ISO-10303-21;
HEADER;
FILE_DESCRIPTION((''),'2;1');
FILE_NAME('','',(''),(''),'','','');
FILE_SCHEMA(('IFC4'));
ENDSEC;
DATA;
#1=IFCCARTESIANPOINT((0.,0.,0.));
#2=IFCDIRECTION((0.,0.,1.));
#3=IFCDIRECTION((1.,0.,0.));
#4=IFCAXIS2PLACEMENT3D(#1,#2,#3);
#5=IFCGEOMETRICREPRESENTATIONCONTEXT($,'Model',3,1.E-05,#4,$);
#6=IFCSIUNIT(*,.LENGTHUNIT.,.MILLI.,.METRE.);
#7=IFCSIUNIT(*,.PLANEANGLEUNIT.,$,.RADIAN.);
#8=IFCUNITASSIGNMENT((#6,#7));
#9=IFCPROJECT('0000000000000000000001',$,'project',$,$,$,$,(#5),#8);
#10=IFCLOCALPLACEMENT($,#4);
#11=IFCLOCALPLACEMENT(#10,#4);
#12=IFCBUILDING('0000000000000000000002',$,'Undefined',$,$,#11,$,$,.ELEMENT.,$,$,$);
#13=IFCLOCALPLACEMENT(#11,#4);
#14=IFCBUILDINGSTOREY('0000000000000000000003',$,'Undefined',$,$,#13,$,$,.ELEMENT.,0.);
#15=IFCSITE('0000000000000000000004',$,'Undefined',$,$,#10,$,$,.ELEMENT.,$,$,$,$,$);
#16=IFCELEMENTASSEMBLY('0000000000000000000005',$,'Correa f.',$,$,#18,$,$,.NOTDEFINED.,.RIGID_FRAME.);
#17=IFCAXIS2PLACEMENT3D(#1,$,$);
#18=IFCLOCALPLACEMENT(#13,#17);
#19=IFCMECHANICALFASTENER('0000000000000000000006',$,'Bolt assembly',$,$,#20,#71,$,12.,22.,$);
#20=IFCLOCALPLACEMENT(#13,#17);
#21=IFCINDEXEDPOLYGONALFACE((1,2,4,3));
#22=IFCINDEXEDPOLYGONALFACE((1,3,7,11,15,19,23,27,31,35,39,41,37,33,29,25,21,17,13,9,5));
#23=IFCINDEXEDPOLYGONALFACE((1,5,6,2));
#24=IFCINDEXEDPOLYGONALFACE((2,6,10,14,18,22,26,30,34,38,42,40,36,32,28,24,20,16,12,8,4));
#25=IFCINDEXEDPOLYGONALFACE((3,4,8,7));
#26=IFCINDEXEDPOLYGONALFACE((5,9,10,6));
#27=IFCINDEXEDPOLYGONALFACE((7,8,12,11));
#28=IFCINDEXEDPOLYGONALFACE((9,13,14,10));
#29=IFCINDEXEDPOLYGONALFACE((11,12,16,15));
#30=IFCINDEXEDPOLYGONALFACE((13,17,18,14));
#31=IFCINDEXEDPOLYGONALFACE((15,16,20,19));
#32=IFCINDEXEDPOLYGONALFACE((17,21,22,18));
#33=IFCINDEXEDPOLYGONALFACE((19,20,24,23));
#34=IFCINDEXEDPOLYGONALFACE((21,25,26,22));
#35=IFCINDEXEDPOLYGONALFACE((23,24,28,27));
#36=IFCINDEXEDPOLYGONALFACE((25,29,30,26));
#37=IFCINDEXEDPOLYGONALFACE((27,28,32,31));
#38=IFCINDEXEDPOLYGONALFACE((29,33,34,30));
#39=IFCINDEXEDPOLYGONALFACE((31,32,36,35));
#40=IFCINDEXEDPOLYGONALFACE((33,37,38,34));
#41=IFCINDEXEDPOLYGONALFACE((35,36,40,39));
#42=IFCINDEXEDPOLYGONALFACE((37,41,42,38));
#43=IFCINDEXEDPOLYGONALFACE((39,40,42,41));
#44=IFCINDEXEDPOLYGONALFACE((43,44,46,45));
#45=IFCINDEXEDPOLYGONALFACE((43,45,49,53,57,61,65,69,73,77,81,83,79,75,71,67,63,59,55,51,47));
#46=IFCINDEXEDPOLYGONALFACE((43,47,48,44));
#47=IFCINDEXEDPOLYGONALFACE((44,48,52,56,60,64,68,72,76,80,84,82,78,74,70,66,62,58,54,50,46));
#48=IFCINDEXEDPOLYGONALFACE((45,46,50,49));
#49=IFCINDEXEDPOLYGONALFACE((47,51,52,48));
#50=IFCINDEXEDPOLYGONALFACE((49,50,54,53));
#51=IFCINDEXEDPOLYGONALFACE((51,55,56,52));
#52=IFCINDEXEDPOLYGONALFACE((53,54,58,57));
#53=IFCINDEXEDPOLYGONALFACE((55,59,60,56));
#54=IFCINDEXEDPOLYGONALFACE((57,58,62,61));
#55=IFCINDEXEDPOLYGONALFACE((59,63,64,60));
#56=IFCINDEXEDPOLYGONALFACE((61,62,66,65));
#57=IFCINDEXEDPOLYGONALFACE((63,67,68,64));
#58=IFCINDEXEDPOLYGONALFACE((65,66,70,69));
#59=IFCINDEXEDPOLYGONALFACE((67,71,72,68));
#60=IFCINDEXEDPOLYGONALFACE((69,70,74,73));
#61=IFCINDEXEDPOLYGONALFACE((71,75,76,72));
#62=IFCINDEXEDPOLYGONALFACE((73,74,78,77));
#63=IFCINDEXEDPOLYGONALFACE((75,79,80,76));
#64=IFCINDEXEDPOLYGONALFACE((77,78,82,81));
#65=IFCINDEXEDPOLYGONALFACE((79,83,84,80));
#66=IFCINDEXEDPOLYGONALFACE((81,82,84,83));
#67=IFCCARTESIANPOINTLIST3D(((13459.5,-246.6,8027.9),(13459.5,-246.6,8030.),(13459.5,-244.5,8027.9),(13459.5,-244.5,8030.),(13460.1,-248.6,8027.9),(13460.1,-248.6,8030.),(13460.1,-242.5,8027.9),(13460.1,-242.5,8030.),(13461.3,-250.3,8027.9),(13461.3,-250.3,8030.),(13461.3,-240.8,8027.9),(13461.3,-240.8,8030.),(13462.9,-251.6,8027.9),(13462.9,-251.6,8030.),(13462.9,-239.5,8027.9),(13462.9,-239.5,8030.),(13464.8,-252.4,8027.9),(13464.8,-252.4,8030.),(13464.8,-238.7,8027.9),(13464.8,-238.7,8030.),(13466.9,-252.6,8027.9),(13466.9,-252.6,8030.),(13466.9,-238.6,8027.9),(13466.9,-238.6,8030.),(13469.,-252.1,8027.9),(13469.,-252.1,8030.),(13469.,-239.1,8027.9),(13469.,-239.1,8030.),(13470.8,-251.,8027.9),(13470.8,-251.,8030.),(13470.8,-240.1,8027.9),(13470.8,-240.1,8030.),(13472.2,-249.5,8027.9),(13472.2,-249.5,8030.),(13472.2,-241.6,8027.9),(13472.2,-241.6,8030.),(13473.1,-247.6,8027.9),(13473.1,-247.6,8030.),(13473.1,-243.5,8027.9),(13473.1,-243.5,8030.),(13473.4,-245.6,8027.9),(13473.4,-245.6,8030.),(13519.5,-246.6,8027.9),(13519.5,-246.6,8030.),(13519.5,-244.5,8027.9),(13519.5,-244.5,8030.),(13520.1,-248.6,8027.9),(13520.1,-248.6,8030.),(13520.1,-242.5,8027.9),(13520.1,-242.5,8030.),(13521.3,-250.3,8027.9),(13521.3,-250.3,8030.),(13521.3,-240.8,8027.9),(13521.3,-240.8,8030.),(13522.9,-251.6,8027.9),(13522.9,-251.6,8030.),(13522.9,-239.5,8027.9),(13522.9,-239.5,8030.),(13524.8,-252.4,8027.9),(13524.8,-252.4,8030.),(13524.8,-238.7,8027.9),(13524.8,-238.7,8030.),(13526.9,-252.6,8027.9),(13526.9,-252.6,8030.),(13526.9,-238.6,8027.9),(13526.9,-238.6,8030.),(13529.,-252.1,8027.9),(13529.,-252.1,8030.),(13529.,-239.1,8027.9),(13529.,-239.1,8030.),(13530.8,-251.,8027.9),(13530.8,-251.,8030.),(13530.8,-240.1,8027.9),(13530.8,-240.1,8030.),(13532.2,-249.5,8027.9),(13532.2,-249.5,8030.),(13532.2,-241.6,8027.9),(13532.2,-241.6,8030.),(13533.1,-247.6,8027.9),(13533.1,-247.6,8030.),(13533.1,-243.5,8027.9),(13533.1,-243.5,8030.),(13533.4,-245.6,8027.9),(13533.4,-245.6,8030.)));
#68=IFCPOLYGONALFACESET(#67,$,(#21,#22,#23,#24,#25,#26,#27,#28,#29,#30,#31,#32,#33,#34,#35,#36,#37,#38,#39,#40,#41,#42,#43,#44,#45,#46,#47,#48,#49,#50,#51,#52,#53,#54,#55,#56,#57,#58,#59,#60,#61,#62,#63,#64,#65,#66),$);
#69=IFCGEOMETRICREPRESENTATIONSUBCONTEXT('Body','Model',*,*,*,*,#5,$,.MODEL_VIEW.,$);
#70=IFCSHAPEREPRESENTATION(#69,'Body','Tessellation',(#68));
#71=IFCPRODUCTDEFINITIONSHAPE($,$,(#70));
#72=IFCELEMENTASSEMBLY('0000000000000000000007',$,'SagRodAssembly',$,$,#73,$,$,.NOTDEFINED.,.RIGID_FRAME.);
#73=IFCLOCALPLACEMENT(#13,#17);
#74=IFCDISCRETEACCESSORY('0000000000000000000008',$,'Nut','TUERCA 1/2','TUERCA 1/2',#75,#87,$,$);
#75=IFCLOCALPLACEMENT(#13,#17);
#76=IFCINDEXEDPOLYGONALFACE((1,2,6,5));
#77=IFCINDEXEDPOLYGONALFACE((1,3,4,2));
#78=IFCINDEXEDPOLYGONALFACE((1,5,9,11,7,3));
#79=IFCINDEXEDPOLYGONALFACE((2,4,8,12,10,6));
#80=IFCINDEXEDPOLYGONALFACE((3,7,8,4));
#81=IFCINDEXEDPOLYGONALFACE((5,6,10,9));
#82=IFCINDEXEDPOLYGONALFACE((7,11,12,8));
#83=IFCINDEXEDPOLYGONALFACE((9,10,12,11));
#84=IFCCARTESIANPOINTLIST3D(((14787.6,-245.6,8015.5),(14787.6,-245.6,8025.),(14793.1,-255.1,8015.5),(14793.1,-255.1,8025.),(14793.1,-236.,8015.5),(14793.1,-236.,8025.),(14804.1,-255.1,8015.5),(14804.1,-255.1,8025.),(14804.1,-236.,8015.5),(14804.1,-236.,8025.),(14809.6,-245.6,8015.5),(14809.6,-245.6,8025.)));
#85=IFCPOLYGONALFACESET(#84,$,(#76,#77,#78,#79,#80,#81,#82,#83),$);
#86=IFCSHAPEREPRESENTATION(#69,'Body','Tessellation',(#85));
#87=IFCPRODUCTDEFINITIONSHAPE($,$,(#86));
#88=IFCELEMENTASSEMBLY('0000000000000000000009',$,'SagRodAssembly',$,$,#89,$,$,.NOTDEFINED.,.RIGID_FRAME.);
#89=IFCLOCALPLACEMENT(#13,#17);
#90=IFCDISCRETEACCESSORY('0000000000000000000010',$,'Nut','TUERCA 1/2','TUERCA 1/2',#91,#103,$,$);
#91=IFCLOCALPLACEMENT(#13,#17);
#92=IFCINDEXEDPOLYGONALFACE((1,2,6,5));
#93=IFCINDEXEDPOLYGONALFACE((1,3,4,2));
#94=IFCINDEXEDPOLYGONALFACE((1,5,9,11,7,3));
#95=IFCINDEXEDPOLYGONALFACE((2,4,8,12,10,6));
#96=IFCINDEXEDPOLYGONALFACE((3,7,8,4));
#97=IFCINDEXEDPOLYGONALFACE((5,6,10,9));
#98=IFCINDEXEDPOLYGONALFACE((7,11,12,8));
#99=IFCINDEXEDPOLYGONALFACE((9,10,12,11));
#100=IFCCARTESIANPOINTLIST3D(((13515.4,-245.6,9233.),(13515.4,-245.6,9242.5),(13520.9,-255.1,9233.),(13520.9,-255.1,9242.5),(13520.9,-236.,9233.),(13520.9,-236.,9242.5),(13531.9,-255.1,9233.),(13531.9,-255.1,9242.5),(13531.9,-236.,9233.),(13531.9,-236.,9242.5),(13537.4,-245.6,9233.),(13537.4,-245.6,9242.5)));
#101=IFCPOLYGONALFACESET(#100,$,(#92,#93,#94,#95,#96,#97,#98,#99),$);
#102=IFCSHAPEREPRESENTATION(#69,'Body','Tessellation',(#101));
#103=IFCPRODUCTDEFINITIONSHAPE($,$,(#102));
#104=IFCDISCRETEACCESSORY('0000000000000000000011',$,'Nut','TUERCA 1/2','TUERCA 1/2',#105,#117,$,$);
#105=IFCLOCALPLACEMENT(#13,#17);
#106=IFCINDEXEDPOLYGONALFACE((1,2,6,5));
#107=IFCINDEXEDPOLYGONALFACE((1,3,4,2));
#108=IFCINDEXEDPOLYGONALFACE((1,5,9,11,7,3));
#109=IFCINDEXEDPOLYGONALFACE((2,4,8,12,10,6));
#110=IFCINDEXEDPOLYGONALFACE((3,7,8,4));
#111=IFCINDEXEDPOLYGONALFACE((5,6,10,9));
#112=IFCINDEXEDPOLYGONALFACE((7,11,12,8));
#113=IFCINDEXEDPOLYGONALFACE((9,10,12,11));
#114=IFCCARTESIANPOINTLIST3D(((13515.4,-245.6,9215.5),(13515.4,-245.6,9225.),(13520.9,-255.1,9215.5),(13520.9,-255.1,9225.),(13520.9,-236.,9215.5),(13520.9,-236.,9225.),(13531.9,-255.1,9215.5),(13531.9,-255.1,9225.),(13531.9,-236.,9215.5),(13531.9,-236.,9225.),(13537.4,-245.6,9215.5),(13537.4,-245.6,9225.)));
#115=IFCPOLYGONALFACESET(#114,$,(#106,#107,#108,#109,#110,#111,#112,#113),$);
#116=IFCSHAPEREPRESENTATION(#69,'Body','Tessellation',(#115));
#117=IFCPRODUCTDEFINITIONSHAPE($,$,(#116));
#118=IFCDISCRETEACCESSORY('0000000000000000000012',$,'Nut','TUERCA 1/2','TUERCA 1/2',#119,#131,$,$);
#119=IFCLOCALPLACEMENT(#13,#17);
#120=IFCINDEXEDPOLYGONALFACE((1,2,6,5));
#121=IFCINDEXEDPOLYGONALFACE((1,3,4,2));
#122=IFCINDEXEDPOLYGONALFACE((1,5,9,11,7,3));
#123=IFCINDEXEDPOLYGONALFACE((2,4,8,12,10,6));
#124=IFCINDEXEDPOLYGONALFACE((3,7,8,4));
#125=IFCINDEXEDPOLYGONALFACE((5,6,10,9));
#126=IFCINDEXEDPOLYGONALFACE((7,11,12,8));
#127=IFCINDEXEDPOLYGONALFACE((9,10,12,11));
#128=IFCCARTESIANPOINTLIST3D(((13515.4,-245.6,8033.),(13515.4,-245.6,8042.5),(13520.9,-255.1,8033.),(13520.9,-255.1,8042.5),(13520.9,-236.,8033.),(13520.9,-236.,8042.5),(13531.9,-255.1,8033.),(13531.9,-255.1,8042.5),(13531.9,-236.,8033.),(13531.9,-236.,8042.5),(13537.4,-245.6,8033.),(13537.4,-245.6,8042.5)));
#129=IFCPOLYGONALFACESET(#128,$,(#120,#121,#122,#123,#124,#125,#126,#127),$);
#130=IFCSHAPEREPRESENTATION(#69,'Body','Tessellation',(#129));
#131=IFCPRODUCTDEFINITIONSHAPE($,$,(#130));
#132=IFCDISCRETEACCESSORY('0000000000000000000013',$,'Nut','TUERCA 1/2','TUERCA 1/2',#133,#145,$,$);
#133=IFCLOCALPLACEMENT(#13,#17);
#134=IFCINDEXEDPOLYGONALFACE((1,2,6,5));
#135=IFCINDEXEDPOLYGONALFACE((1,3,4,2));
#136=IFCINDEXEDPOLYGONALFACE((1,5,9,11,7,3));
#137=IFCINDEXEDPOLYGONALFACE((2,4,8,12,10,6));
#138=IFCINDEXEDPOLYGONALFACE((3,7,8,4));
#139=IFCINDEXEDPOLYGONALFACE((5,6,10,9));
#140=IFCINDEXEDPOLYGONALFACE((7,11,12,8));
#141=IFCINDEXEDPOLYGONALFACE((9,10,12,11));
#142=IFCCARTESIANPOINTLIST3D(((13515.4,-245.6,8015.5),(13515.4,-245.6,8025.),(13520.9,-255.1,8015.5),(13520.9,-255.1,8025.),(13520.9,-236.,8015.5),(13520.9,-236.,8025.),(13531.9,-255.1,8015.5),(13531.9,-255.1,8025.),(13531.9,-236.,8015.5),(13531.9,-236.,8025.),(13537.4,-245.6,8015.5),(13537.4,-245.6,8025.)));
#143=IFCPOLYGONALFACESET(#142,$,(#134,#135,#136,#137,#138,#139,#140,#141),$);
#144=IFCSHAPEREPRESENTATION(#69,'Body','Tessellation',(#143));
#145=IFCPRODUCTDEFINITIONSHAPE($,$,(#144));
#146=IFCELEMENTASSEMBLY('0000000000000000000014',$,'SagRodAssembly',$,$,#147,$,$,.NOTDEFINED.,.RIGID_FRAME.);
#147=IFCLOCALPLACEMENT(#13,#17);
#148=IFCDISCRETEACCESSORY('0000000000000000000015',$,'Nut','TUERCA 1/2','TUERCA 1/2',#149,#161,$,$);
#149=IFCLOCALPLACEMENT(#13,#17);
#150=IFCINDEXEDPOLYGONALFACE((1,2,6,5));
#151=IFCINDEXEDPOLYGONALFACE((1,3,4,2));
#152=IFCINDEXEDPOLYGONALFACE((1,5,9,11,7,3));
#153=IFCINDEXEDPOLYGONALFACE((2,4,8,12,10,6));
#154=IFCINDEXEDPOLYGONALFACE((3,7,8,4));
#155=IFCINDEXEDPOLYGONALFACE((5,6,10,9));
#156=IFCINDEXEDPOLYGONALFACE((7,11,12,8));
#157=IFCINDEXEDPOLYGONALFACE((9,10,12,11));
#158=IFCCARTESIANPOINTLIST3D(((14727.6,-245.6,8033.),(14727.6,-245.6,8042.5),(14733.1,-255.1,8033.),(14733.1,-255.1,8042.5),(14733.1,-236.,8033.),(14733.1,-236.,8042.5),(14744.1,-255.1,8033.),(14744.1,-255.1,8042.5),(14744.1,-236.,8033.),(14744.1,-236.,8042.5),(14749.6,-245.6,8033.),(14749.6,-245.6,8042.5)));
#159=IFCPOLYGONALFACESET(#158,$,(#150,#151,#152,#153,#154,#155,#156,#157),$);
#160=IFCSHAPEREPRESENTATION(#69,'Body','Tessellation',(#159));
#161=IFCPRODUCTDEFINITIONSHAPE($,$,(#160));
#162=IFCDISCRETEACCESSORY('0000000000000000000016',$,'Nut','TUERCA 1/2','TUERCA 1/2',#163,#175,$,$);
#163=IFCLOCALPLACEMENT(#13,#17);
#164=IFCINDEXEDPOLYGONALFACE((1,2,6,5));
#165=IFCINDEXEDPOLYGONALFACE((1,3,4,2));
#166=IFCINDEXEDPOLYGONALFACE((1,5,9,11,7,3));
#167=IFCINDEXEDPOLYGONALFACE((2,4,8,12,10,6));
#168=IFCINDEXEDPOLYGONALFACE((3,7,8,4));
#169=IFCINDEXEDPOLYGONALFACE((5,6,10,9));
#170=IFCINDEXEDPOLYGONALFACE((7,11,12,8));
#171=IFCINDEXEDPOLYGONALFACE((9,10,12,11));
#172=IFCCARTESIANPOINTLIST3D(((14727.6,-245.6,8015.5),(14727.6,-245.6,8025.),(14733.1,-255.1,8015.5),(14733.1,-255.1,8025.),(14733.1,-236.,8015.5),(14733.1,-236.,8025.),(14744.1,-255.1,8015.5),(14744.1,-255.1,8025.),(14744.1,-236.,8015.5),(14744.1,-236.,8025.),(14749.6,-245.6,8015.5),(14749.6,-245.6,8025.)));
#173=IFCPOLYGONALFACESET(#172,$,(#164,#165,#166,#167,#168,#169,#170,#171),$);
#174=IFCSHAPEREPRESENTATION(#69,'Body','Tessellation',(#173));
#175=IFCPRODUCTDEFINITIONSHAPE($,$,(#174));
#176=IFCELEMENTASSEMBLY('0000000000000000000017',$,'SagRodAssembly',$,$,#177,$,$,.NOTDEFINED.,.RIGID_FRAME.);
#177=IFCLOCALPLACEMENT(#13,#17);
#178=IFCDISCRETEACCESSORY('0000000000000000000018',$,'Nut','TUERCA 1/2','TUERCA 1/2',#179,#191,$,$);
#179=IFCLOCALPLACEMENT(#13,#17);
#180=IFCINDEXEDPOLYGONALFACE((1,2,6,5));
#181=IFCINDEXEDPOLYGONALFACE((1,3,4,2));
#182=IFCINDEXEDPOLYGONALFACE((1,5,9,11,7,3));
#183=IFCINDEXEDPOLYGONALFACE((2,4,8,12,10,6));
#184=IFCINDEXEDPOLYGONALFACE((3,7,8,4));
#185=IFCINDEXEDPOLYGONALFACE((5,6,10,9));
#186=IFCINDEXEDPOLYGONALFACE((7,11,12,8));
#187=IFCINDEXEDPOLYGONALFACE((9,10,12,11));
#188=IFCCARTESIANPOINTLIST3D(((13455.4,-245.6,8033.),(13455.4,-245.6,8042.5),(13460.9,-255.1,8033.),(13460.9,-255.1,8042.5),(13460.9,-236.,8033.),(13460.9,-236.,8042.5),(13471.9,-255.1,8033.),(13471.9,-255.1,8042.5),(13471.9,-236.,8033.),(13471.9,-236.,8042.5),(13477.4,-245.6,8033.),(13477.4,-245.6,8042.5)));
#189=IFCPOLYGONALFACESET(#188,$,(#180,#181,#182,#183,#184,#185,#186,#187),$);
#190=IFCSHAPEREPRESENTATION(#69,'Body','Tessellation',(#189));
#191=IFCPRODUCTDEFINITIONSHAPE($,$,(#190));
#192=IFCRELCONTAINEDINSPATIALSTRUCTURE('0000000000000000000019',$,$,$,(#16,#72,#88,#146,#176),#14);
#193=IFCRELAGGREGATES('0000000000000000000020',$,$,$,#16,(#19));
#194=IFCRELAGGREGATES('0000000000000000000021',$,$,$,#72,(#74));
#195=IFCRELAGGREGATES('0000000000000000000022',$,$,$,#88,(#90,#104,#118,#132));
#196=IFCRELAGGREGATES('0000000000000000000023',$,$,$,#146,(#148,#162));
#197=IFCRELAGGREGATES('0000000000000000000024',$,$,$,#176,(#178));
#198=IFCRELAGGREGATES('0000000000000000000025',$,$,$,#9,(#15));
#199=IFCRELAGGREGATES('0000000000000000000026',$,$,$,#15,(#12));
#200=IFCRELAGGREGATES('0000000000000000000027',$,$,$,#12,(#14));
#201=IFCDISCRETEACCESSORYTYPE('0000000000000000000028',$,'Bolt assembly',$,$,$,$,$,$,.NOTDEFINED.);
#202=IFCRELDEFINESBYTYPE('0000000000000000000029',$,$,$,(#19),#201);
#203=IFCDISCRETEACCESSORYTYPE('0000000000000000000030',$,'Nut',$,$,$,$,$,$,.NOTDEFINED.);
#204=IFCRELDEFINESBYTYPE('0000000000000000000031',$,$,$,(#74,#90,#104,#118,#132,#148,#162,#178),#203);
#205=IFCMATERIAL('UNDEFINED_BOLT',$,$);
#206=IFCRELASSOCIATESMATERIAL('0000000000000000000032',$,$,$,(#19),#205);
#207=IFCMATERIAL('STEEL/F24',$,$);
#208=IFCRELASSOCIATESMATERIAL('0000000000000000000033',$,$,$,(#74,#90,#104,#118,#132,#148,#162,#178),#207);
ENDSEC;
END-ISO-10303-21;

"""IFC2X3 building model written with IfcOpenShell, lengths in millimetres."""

from ifc_helpers import new_model, si_unit, frame, origin_with_axes, origin_2d_with_axis, place, context, subcontext, project, spatial, polyline, circle, outline, extrude, source, transform, mapped, material, type_object, element, aggregate, save


model = new_model("IFC2X3")

# Units and contexts
model_context = context("Model", 3, precision=1e-05, world=origin_with_axes())
body_context = subcontext(model_context, "Body", "Model", "MODEL_VIEW")
ifc_project = project(units=[si_unit("LENGTHUNIT", "METRE", prefix="MILLI"), si_unit("PLANEANGLEUNIT", "RADIAN")], contexts=[model_context])

# Site, building, storey
site_placement = place(None, origin_with_axes())
site = spatial("IfcSite", under=ifc_project, at=site_placement, Name="Undefined", CompositionType="ELEMENT")
building_placement = place(site_placement, origin_with_axes())
building = spatial("IfcBuilding", under=site, at=building_placement, Name="Undefined", CompositionType="ELEMENT")
storey_placement = place(building_placement, origin_with_axes())
storey = spatial("IfcBuildingStorey", under=building, at=storey_placement, Name="Undefined", CompositionType="ELEMENT", Elevation=0.0)

# Shared definitions
ifc_material_1 = material(Name="STEEL/F24")

# Shared definitions
ifc_material_2 = material(Name="UNDEFINED_BOLT")
discrete_accessory_type_1 = type_object("IfcDiscreteAccessoryType", Name="Bolt assembly")
shared_shape = source(origin_with_axes(), body_context, "Body", "SweptSolid", [
    extrude(circle(Radius=7.0, at=origin_2d_with_axis()), frame((0.0, -1.0, 0.0), z_axis=(0.0, 1.0, 0.0), x_axis=(1.0, 0.0, 0.0)), (0.0, 0.0, 1.0), 2.1),
])

# Element assembly, mechanical fastener
assembly_1_placement = place(storey_placement, origin_with_axes())
assembly_1 = element("IfcElementAssembly", 1, at=assembly_1_placement, inside=storey, Name="Correa f.", AssemblyPlace="NOTDEFINED", PredefinedType="RIGID_FRAME")
mechanical_fastener_1_placement = place(assembly_1_placement, frame((13466.4, -245.6, 8029.0), z_axis=(0.0, 1.0, 0.0), x_axis=(1.0, 0.0, 0.0)))
mechanical_fastener_1 = element("IfcMechanicalFastener", 2, at=mechanical_fastener_1_placement, type_object=discrete_accessory_type_1, material=ifc_material_2, Name="Bolt assembly", NominalDiameter=12.0, NominalLength=22.0, context=body_context, shape_type="MappedRepresentation", body=[
    mapped(shared_shape, transform((0.0, 0.0, 0.0))),
    mapped(shared_shape, transform((60.0, 0.0, 0.0))),
])
aggregate(assembly_1, [mechanical_fastener_1])

# Element assembly, discrete accessory
assembly_2_placement = place(storey_placement, origin_with_axes())
assembly_2 = element("IfcElementAssembly", 3, at=assembly_2_placement, inside=storey, Name="SagRodAssembly", AssemblyPlace="NOTDEFINED", PredefinedType="RIGID_FRAME")
discrete_accessory_type_2 = type_object("IfcDiscreteAccessoryType", Name="Nut")
discrete_accessory_1_placement = place(assembly_2_placement, frame((14798.6, -245.6, 8015.5), z_axis=(0.0, 0.0, 1.0), x_axis=(0.0, 1.0, 0.0)))
discrete_accessory_1 = element("IfcDiscreteAccessory", 4, at=discrete_accessory_1_placement, type_object=discrete_accessory_type_2, material=ifc_material_1, Name="Nut", Description="TUERCA 1/2", ObjectType="TUERCA 1/2", context=body_context, shape_type="SweptSolid", body=[
    extrude(outline(polyline([(-5.5, 9.5), (5.5, 9.5), (11.0, 0.0), (5.5, -9.5), (-5.5, -9.5), (-11.0, 0.0), (-5.5, 9.5)])), frame((0.0, 0.0, 9.5), z_axis=(0.0, 0.0, -1.0), x_axis=(0.0, 1.0, 0.0)), (0.0, 0.0, 1.0), 9.5),
])
aggregate(assembly_2, [discrete_accessory_1])

# Element assemblies, discrete accessories
assembly_3_placement = place(storey_placement, origin_with_axes())
assembly_3 = element("IfcElementAssembly", 5, at=assembly_3_placement, inside=storey, Name="SagRodAssembly", AssemblyPlace="NOTDEFINED", PredefinedType="RIGID_FRAME")
discrete_accessory_2_placement = place(assembly_3_placement, frame((13526.4, -245.6, 9233.0), z_axis=(0.0, 0.0, 1.0), x_axis=(0.0, 1.0, 0.0)))
discrete_accessory_2 = element("IfcDiscreteAccessory", 6, at=discrete_accessory_2_placement, type_object=discrete_accessory_type_2, material=ifc_material_1, Name="Nut", Description="TUERCA 1/2", ObjectType="TUERCA 1/2", context=body_context, shape_type="SweptSolid", body=[
    extrude(outline(polyline([(-5.5, 9.5), (5.5, 9.5), (11.0, 0.0), (5.5, -9.5), (-5.5, -9.5), (-11.0, 0.0), (-5.5, 9.5)])), frame((0.0, 0.0, 9.5), z_axis=(0.0, 0.0, -1.0), x_axis=(0.0, 1.0, 0.0)), (0.0, 0.0, 1.0), 9.5),
])
discrete_accessory_3_placement = place(assembly_3_placement, frame((13526.4, -245.6, 9215.5), z_axis=(0.0, 0.0, 1.0), x_axis=(0.0, 1.0, 0.0)))
discrete_accessory_3 = element("IfcDiscreteAccessory", 7, at=discrete_accessory_3_placement, type_object=discrete_accessory_type_2, material=ifc_material_1, Name="Nut", Description="TUERCA 1/2", ObjectType="TUERCA 1/2", context=body_context, shape_type="SweptSolid", body=[
    extrude(outline(polyline([(-5.5, 9.5), (5.5, 9.5), (11.0, 0.0), (5.5, -9.5), (-5.5, -9.5), (-11.0, 0.0), (-5.5, 9.5)])), frame((0.0, 0.0, 9.5), z_axis=(0.0, 0.0, -1.0), x_axis=(0.0, 1.0, 0.0)), (0.0, 0.0, 1.0), 9.5),
])
discrete_accessory_4_placement = place(assembly_3_placement, frame((13526.4, -245.6, 8033.0), z_axis=(0.0, 0.0, 1.0), x_axis=(0.0, 1.0, 0.0)))
discrete_accessory_4 = element("IfcDiscreteAccessory", 8, at=discrete_accessory_4_placement, type_object=discrete_accessory_type_2, material=ifc_material_1, Name="Nut", Description="TUERCA 1/2", ObjectType="TUERCA 1/2", context=body_context, shape_type="SweptSolid", body=[
    extrude(outline(polyline([(-5.5, 9.5), (5.5, 9.5), (11.0, 0.0), (5.5, -9.5), (-5.5, -9.5), (-11.0, 0.0), (-5.5, 9.5)])), frame((0.0, 0.0, 9.5), z_axis=(0.0, 0.0, -1.0), x_axis=(0.0, 1.0, 0.0)), (0.0, 0.0, 1.0), 9.5),
])
discrete_accessory_5_placement = place(assembly_3_placement, frame((13526.4, -245.6, 8015.5), z_axis=(0.0, 0.0, 1.0), x_axis=(0.0, 1.0, 0.0)))
discrete_accessory_5 = element("IfcDiscreteAccessory", 9, at=discrete_accessory_5_placement, type_object=discrete_accessory_type_2, material=ifc_material_1, Name="Nut", Description="TUERCA 1/2", ObjectType="TUERCA 1/2", context=body_context, shape_type="SweptSolid", body=[
    extrude(outline(polyline([(-5.5, 9.5), (5.5, 9.5), (11.0, 0.0), (5.5, -9.5), (-5.5, -9.5), (-11.0, 0.0), (-5.5, 9.5)])), frame((0.0, 0.0, 9.5), z_axis=(0.0, 0.0, -1.0), x_axis=(0.0, 1.0, 0.0)), (0.0, 0.0, 1.0), 9.5),
])
assembly_4_placement = place(storey_placement, origin_with_axes())
assembly_4 = element("IfcElementAssembly", 10, at=assembly_4_placement, inside=storey, Name="SagRodAssembly", AssemblyPlace="NOTDEFINED", PredefinedType="RIGID_FRAME")
discrete_accessory_6_placement = place(assembly_4_placement, frame((14738.6, -245.6, 8033.0), z_axis=(0.0, 0.0, 1.0), x_axis=(0.0, 1.0, 0.0)))
discrete_accessory_6 = element("IfcDiscreteAccessory", 11, at=discrete_accessory_6_placement, type_object=discrete_accessory_type_2, material=ifc_material_1, Name="Nut", Description="TUERCA 1/2", ObjectType="TUERCA 1/2", context=body_context, shape_type="SweptSolid", body=[
    extrude(outline(polyline([(-5.5, 9.5), (5.5, 9.5), (11.0, 0.0), (5.5, -9.5), (-5.5, -9.5), (-11.0, 0.0), (-5.5, 9.5)])), frame((0.0, 0.0, 9.5), z_axis=(0.0, 0.0, -1.0), x_axis=(0.0, 1.0, 0.0)), (0.0, 0.0, 1.0), 9.5),
])
discrete_accessory_7_placement = place(assembly_4_placement, frame((14738.6, -245.6, 8015.5), z_axis=(0.0, 0.0, 1.0), x_axis=(0.0, 1.0, 0.0)))
discrete_accessory_7 = element("IfcDiscreteAccessory", 12, at=discrete_accessory_7_placement, type_object=discrete_accessory_type_2, material=ifc_material_1, Name="Nut", Description="TUERCA 1/2", ObjectType="TUERCA 1/2", context=body_context, shape_type="SweptSolid", body=[
    extrude(outline(polyline([(-5.5, 9.5), (5.5, 9.5), (11.0, 0.0), (5.5, -9.5), (-5.5, -9.5), (-11.0, 0.0), (-5.5, 9.5)])), frame((0.0, 0.0, 9.5), z_axis=(0.0, 0.0, -1.0), x_axis=(0.0, 1.0, 0.0)), (0.0, 0.0, 1.0), 9.5),
])
assembly_5_placement = place(storey_placement, origin_with_axes())
assembly_5 = element("IfcElementAssembly", 13, at=assembly_5_placement, inside=storey, Name="SagRodAssembly", AssemblyPlace="NOTDEFINED", PredefinedType="RIGID_FRAME")
discrete_accessory_8_placement = place(assembly_5_placement, frame((13466.4, -245.6, 8033.0), z_axis=(0.0, 0.0, 1.0), x_axis=(0.0, 1.0, 0.0)))
discrete_accessory_8 = element("IfcDiscreteAccessory", 14, at=discrete_accessory_8_placement, type_object=discrete_accessory_type_2, material=ifc_material_1, Name="Nut", Description="TUERCA 1/2", ObjectType="TUERCA 1/2", context=body_context, shape_type="SweptSolid", body=[
    extrude(outline(polyline([(-5.5, 9.5), (5.5, 9.5), (11.0, 0.0), (5.5, -9.5), (-5.5, -9.5), (-11.0, 0.0), (-5.5, 9.5)])), frame((0.0, 0.0, 9.5), z_axis=(0.0, 0.0, -1.0), x_axis=(0.0, 1.0, 0.0)), (0.0, 0.0, 1.0), 9.5),
])

aggregate(assembly_3, [discrete_accessory_2, discrete_accessory_3, discrete_accessory_4, discrete_accessory_5])
aggregate(assembly_4, [discrete_accessory_6, discrete_accessory_7])
aggregate(assembly_5, [discrete_accessory_8])

save(model, "model.ifc")
